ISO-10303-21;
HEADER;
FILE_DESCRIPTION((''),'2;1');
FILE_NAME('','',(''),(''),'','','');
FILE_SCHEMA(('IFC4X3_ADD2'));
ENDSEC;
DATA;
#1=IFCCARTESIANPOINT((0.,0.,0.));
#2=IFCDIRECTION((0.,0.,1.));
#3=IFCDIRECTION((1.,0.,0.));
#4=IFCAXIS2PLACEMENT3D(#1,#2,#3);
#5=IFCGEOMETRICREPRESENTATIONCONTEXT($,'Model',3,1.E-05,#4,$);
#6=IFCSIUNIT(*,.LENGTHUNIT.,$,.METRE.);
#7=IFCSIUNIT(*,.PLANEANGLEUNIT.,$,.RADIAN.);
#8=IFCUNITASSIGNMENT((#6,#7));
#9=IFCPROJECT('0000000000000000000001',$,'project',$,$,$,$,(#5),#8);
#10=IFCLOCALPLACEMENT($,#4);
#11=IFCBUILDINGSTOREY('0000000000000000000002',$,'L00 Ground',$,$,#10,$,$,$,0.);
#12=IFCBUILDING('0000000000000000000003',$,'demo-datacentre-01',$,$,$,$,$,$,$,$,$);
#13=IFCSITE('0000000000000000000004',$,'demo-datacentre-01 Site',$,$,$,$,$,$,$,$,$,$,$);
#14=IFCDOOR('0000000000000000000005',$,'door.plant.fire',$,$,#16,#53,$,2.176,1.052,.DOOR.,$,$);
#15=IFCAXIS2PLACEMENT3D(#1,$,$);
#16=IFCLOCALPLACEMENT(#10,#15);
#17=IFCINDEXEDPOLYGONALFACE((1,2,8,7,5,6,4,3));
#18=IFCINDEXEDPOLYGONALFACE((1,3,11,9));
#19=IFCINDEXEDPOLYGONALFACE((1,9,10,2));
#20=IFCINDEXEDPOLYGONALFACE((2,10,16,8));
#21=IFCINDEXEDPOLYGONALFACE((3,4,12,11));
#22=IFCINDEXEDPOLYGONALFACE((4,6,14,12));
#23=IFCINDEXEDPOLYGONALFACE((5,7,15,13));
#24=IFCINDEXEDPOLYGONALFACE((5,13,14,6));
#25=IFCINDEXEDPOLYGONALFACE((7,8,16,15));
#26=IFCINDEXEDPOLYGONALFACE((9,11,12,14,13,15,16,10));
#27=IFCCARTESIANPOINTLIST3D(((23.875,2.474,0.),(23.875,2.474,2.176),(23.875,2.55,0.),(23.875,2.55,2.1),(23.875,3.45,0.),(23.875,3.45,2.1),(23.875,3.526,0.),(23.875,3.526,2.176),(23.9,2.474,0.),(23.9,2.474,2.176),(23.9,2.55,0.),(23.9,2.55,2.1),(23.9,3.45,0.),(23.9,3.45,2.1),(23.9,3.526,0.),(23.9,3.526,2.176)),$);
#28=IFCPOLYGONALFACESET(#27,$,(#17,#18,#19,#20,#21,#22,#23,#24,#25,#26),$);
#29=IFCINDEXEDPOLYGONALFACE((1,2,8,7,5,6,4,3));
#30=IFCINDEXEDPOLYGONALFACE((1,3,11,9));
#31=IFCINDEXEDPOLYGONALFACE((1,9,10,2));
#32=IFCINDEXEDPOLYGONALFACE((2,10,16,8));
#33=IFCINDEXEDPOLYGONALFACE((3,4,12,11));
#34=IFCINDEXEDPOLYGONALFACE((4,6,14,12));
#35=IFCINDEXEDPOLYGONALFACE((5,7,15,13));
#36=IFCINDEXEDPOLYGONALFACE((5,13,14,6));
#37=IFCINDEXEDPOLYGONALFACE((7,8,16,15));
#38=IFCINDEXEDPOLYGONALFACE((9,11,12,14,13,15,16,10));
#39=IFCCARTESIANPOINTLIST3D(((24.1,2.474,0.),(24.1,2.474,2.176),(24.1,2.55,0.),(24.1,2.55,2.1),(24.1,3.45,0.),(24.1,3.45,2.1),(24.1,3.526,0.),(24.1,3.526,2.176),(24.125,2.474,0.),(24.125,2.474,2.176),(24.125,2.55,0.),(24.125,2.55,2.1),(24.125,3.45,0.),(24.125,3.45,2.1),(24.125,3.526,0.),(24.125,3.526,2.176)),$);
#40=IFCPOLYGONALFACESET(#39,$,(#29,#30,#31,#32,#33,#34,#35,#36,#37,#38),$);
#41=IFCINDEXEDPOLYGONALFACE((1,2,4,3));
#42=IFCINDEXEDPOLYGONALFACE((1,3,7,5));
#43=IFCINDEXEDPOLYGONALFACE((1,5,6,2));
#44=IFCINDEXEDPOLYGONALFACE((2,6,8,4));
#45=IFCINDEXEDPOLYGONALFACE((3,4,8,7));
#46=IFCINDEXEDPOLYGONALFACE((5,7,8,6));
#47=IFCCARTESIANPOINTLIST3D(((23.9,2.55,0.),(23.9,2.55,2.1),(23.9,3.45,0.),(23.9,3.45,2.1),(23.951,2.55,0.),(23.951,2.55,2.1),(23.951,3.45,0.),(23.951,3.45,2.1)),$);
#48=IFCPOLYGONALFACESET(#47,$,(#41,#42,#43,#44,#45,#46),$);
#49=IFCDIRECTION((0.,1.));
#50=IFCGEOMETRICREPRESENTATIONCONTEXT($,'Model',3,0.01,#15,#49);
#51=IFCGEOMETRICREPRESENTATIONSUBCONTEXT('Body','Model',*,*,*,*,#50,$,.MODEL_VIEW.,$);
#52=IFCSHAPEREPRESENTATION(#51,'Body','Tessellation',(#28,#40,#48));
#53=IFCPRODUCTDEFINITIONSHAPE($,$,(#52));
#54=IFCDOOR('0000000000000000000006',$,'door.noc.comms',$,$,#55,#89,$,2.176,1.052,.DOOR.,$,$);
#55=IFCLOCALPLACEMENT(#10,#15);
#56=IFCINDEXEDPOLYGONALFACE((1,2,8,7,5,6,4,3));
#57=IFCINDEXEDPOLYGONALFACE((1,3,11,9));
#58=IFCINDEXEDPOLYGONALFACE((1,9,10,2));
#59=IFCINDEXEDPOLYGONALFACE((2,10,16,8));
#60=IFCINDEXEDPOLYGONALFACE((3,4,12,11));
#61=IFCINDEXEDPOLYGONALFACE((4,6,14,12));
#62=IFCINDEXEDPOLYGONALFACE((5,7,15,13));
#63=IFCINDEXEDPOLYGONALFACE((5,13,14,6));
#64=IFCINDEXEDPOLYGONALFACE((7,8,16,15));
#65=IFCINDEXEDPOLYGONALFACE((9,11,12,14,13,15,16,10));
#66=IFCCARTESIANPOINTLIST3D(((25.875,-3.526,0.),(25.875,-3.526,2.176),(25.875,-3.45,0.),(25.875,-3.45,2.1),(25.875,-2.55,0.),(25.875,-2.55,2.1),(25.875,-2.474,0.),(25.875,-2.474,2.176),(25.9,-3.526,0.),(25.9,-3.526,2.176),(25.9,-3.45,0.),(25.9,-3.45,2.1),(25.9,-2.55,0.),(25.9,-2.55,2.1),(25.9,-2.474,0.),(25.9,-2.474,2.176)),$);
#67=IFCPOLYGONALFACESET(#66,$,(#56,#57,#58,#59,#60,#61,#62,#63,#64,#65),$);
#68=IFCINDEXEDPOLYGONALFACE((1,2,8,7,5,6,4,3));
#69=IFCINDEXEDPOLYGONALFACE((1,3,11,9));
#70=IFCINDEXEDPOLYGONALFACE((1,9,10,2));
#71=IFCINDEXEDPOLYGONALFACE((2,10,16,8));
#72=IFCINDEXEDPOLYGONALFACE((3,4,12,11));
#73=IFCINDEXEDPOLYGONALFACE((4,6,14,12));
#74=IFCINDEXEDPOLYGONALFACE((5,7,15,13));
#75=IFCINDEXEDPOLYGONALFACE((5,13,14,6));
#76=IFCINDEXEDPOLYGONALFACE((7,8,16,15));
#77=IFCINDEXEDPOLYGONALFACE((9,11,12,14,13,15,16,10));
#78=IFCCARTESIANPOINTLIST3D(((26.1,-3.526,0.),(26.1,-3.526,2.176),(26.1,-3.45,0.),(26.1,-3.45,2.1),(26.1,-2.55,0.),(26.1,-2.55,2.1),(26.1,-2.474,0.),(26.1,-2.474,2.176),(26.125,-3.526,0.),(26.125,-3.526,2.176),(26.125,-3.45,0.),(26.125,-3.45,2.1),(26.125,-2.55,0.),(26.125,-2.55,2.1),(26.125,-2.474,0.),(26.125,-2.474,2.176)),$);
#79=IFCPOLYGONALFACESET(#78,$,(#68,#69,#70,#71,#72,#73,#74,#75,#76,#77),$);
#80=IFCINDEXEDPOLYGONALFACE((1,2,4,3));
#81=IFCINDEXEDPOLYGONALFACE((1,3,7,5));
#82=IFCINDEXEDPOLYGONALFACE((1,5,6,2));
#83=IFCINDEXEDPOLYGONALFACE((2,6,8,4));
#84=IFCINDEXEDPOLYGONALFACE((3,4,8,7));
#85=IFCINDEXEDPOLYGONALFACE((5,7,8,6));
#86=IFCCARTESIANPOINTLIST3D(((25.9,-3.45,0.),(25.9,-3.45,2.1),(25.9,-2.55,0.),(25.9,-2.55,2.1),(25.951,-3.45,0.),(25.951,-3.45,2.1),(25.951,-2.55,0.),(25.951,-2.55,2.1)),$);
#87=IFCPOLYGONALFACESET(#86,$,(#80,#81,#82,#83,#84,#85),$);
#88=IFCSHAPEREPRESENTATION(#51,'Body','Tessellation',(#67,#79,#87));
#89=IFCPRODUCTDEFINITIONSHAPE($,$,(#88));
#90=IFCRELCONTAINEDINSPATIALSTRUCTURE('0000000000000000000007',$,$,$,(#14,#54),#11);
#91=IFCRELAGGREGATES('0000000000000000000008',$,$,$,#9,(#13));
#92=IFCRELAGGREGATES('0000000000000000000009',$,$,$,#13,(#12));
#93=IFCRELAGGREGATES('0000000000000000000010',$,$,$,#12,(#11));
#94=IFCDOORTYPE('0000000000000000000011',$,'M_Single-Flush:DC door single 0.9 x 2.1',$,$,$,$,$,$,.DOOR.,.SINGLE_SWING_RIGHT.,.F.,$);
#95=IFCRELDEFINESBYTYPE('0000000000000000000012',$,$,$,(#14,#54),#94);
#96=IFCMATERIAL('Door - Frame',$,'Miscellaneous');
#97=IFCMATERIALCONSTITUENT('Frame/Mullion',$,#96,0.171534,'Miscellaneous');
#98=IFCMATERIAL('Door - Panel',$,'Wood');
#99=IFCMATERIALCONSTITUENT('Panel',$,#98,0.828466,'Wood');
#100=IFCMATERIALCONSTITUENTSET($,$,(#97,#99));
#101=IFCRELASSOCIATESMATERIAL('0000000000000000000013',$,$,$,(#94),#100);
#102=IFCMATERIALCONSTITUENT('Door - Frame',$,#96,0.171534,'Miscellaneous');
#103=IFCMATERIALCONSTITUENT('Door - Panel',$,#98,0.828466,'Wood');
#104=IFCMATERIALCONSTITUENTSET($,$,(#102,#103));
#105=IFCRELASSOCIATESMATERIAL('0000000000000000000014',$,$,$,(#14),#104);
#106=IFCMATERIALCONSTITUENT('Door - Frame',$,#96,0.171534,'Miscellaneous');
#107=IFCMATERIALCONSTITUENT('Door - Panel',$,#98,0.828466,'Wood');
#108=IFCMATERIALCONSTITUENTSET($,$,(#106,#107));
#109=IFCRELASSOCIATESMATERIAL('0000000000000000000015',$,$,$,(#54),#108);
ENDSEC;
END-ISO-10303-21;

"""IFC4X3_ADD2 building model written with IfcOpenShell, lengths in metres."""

from ifc_helpers import new_model, si_unit, direction, frame, frame_2d, origin, origin_with_axes, place, context, subcontext, project, spatial, polyline, rectangle, outline, extrude, source, transform, mapped, material, constituent, constituent_set, type_object, type_shapes, element, save


model = new_model("IFC4X3_ADD2")

# Units and contexts
model_context_1 = context("Model", 3, precision=0.01, world=origin(), true_north=direction((0.0, 1.0)))
model_context_2 = context("Model", 3, precision=1e-05, world=origin_with_axes())
body_context = subcontext(model_context_1, "Body", "Model", "MODEL_VIEW")
ifc_project = project(units=[si_unit("LENGTHUNIT", "METRE"), si_unit("PLANEANGLEUNIT", "RADIAN")], contexts=[model_context_2])

# Site, building, storey
site = spatial("IfcSite", under=ifc_project, Name="demo-datacentre-01 Site")
building = spatial("IfcBuilding", under=site, Name="demo-datacentre-01")
storey_placement = place(None, origin_with_axes())
storey = spatial("IfcBuildingStorey", under=building, at=storey_placement, Name="L00 Ground", Elevation=0.0)

# Shared definitions
placement_1 = place(None, origin())
placement_2 = place(placement_1, origin())
placement_3 = place(placement_2, origin())

# Doors
ifc_material_1 = material(Name="Door - Frame", Category="Miscellaneous")
ifc_material_2 = material(Name="Door - Panel", Category="Wood")
ifc_constituent_1 = constituent(ifc_material_1, Name="Door - Frame", Category="Miscellaneous", fraction=0.171534)
ifc_constituent_2 = constituent(ifc_material_2, Name="Door - Panel", Category="Wood", fraction=0.828466)
ifc_constituent_set_1 = constituent_set(constituents=[ifc_constituent_1, ifc_constituent_2])
ifc_constituent_3 = constituent(ifc_material_1, Name="Frame/Mullion", Category="Miscellaneous", fraction=0.171534)
ifc_constituent_4 = constituent(ifc_material_2, Name="Panel", Category="Wood", fraction=0.828466)
ifc_constituent_set_2 = constituent_set(constituents=[ifc_constituent_3, ifc_constituent_4])
door_type_1 = type_object("IfcDoorType", Name="M_Single-Flush:DC door single 0.9 x 2.1", OperationType="SINGLE_SWING_RIGHT", ParameterTakesPrecedence=False, PredefinedType="DOOR", material=ifc_constituent_set_2)
shared_shape_1 = source(origin(), body_context, "Body", "SweptSolid", [
    extrude(outline(polyline([(-0.526, -1.107), (0.526, -1.107), (0.526, 1.069), (0.45, 1.069), (0.45, -1.031), (-0.45, -1.031), (-0.45, 1.069), (-0.526, 1.069), (-0.526, -1.107)])), frame((0.45, 0.2, 1.069), z_axis=(0.0, 1.0, 0.0), x_axis=(1.0, 0.0, 0.0)), (0.0, 0.0, 1.0), 0.025),
    extrude(outline(polyline([(-1.107, -0.526), (1.069, -0.526), (1.069, -0.45), (-1.031, -0.45), (-1.031, 0.45), (1.069, 0.45), (1.069, 0.526), (-1.107, 0.526), (-1.107, -0.526)])), frame((0.45, -0.025, 1.069), z_axis=(0.0, 1.0, 0.0), x_axis=(0.0, 0.0, -1.0)), (0.0, 0.0, 1.0), 0.025),
    extrude(rectangle(XDim=0.051, YDim=0.9, at=frame_2d((0.0, 0.0), x_axis=(1.0, 0.0))), frame((0.45, 0.1745, 0.0), z_axis=(0.0, 0.0, 1.0), x_axis=(0.0, 1.0, 0.0)), (0.0, 0.0, 1.0), 2.1),
])
type_shapes(door_type_1, [shared_shape_1])
door_1_placement = place(placement_3, frame((24.1, 2.55, 0.0), z_axis=(0.0, 0.0, 1.0), x_axis=(0.0, 1.0, 0.0)))
element("IfcDoor", 1, at=door_1_placement, inside=storey, type_object=door_type_1, material=ifc_constituent_set_1, Name="door.plant.fire", OverallHeight=2.176, OverallWidth=1.052, PredefinedType="DOOR", context=body_context, shape_type="MappedRepresentation", body=[
    mapped(shared_shape_1, transform((0.0, 0.0, 0.0), scale=1.0)),
])
ifc_constituent_5 = constituent(ifc_material_1, Name="Door - Frame", Category="Miscellaneous", fraction=0.171534)
ifc_constituent_6 = constituent(ifc_material_2, Name="Door - Panel", Category="Wood", fraction=0.828466)
ifc_constituent_set_3 = constituent_set(constituents=[ifc_constituent_5, ifc_constituent_6])
door_2_placement = place(placement_3, frame((26.1, -3.45, 0.0), z_axis=(0.0, 0.0, 1.0), x_axis=(0.0, 1.0, 0.0)))
element("IfcDoor", 2, at=door_2_placement, inside=storey, type_object=door_type_1, material=ifc_constituent_set_3, Name="door.noc.comms", OverallHeight=2.176, OverallWidth=1.052, PredefinedType="DOOR", context=body_context, shape_type="MappedRepresentation", body=[
    mapped(shared_shape_1, transform((0.0, 0.0, 0.0), scale=1.0)),
])

save(model, "model.ifc")
